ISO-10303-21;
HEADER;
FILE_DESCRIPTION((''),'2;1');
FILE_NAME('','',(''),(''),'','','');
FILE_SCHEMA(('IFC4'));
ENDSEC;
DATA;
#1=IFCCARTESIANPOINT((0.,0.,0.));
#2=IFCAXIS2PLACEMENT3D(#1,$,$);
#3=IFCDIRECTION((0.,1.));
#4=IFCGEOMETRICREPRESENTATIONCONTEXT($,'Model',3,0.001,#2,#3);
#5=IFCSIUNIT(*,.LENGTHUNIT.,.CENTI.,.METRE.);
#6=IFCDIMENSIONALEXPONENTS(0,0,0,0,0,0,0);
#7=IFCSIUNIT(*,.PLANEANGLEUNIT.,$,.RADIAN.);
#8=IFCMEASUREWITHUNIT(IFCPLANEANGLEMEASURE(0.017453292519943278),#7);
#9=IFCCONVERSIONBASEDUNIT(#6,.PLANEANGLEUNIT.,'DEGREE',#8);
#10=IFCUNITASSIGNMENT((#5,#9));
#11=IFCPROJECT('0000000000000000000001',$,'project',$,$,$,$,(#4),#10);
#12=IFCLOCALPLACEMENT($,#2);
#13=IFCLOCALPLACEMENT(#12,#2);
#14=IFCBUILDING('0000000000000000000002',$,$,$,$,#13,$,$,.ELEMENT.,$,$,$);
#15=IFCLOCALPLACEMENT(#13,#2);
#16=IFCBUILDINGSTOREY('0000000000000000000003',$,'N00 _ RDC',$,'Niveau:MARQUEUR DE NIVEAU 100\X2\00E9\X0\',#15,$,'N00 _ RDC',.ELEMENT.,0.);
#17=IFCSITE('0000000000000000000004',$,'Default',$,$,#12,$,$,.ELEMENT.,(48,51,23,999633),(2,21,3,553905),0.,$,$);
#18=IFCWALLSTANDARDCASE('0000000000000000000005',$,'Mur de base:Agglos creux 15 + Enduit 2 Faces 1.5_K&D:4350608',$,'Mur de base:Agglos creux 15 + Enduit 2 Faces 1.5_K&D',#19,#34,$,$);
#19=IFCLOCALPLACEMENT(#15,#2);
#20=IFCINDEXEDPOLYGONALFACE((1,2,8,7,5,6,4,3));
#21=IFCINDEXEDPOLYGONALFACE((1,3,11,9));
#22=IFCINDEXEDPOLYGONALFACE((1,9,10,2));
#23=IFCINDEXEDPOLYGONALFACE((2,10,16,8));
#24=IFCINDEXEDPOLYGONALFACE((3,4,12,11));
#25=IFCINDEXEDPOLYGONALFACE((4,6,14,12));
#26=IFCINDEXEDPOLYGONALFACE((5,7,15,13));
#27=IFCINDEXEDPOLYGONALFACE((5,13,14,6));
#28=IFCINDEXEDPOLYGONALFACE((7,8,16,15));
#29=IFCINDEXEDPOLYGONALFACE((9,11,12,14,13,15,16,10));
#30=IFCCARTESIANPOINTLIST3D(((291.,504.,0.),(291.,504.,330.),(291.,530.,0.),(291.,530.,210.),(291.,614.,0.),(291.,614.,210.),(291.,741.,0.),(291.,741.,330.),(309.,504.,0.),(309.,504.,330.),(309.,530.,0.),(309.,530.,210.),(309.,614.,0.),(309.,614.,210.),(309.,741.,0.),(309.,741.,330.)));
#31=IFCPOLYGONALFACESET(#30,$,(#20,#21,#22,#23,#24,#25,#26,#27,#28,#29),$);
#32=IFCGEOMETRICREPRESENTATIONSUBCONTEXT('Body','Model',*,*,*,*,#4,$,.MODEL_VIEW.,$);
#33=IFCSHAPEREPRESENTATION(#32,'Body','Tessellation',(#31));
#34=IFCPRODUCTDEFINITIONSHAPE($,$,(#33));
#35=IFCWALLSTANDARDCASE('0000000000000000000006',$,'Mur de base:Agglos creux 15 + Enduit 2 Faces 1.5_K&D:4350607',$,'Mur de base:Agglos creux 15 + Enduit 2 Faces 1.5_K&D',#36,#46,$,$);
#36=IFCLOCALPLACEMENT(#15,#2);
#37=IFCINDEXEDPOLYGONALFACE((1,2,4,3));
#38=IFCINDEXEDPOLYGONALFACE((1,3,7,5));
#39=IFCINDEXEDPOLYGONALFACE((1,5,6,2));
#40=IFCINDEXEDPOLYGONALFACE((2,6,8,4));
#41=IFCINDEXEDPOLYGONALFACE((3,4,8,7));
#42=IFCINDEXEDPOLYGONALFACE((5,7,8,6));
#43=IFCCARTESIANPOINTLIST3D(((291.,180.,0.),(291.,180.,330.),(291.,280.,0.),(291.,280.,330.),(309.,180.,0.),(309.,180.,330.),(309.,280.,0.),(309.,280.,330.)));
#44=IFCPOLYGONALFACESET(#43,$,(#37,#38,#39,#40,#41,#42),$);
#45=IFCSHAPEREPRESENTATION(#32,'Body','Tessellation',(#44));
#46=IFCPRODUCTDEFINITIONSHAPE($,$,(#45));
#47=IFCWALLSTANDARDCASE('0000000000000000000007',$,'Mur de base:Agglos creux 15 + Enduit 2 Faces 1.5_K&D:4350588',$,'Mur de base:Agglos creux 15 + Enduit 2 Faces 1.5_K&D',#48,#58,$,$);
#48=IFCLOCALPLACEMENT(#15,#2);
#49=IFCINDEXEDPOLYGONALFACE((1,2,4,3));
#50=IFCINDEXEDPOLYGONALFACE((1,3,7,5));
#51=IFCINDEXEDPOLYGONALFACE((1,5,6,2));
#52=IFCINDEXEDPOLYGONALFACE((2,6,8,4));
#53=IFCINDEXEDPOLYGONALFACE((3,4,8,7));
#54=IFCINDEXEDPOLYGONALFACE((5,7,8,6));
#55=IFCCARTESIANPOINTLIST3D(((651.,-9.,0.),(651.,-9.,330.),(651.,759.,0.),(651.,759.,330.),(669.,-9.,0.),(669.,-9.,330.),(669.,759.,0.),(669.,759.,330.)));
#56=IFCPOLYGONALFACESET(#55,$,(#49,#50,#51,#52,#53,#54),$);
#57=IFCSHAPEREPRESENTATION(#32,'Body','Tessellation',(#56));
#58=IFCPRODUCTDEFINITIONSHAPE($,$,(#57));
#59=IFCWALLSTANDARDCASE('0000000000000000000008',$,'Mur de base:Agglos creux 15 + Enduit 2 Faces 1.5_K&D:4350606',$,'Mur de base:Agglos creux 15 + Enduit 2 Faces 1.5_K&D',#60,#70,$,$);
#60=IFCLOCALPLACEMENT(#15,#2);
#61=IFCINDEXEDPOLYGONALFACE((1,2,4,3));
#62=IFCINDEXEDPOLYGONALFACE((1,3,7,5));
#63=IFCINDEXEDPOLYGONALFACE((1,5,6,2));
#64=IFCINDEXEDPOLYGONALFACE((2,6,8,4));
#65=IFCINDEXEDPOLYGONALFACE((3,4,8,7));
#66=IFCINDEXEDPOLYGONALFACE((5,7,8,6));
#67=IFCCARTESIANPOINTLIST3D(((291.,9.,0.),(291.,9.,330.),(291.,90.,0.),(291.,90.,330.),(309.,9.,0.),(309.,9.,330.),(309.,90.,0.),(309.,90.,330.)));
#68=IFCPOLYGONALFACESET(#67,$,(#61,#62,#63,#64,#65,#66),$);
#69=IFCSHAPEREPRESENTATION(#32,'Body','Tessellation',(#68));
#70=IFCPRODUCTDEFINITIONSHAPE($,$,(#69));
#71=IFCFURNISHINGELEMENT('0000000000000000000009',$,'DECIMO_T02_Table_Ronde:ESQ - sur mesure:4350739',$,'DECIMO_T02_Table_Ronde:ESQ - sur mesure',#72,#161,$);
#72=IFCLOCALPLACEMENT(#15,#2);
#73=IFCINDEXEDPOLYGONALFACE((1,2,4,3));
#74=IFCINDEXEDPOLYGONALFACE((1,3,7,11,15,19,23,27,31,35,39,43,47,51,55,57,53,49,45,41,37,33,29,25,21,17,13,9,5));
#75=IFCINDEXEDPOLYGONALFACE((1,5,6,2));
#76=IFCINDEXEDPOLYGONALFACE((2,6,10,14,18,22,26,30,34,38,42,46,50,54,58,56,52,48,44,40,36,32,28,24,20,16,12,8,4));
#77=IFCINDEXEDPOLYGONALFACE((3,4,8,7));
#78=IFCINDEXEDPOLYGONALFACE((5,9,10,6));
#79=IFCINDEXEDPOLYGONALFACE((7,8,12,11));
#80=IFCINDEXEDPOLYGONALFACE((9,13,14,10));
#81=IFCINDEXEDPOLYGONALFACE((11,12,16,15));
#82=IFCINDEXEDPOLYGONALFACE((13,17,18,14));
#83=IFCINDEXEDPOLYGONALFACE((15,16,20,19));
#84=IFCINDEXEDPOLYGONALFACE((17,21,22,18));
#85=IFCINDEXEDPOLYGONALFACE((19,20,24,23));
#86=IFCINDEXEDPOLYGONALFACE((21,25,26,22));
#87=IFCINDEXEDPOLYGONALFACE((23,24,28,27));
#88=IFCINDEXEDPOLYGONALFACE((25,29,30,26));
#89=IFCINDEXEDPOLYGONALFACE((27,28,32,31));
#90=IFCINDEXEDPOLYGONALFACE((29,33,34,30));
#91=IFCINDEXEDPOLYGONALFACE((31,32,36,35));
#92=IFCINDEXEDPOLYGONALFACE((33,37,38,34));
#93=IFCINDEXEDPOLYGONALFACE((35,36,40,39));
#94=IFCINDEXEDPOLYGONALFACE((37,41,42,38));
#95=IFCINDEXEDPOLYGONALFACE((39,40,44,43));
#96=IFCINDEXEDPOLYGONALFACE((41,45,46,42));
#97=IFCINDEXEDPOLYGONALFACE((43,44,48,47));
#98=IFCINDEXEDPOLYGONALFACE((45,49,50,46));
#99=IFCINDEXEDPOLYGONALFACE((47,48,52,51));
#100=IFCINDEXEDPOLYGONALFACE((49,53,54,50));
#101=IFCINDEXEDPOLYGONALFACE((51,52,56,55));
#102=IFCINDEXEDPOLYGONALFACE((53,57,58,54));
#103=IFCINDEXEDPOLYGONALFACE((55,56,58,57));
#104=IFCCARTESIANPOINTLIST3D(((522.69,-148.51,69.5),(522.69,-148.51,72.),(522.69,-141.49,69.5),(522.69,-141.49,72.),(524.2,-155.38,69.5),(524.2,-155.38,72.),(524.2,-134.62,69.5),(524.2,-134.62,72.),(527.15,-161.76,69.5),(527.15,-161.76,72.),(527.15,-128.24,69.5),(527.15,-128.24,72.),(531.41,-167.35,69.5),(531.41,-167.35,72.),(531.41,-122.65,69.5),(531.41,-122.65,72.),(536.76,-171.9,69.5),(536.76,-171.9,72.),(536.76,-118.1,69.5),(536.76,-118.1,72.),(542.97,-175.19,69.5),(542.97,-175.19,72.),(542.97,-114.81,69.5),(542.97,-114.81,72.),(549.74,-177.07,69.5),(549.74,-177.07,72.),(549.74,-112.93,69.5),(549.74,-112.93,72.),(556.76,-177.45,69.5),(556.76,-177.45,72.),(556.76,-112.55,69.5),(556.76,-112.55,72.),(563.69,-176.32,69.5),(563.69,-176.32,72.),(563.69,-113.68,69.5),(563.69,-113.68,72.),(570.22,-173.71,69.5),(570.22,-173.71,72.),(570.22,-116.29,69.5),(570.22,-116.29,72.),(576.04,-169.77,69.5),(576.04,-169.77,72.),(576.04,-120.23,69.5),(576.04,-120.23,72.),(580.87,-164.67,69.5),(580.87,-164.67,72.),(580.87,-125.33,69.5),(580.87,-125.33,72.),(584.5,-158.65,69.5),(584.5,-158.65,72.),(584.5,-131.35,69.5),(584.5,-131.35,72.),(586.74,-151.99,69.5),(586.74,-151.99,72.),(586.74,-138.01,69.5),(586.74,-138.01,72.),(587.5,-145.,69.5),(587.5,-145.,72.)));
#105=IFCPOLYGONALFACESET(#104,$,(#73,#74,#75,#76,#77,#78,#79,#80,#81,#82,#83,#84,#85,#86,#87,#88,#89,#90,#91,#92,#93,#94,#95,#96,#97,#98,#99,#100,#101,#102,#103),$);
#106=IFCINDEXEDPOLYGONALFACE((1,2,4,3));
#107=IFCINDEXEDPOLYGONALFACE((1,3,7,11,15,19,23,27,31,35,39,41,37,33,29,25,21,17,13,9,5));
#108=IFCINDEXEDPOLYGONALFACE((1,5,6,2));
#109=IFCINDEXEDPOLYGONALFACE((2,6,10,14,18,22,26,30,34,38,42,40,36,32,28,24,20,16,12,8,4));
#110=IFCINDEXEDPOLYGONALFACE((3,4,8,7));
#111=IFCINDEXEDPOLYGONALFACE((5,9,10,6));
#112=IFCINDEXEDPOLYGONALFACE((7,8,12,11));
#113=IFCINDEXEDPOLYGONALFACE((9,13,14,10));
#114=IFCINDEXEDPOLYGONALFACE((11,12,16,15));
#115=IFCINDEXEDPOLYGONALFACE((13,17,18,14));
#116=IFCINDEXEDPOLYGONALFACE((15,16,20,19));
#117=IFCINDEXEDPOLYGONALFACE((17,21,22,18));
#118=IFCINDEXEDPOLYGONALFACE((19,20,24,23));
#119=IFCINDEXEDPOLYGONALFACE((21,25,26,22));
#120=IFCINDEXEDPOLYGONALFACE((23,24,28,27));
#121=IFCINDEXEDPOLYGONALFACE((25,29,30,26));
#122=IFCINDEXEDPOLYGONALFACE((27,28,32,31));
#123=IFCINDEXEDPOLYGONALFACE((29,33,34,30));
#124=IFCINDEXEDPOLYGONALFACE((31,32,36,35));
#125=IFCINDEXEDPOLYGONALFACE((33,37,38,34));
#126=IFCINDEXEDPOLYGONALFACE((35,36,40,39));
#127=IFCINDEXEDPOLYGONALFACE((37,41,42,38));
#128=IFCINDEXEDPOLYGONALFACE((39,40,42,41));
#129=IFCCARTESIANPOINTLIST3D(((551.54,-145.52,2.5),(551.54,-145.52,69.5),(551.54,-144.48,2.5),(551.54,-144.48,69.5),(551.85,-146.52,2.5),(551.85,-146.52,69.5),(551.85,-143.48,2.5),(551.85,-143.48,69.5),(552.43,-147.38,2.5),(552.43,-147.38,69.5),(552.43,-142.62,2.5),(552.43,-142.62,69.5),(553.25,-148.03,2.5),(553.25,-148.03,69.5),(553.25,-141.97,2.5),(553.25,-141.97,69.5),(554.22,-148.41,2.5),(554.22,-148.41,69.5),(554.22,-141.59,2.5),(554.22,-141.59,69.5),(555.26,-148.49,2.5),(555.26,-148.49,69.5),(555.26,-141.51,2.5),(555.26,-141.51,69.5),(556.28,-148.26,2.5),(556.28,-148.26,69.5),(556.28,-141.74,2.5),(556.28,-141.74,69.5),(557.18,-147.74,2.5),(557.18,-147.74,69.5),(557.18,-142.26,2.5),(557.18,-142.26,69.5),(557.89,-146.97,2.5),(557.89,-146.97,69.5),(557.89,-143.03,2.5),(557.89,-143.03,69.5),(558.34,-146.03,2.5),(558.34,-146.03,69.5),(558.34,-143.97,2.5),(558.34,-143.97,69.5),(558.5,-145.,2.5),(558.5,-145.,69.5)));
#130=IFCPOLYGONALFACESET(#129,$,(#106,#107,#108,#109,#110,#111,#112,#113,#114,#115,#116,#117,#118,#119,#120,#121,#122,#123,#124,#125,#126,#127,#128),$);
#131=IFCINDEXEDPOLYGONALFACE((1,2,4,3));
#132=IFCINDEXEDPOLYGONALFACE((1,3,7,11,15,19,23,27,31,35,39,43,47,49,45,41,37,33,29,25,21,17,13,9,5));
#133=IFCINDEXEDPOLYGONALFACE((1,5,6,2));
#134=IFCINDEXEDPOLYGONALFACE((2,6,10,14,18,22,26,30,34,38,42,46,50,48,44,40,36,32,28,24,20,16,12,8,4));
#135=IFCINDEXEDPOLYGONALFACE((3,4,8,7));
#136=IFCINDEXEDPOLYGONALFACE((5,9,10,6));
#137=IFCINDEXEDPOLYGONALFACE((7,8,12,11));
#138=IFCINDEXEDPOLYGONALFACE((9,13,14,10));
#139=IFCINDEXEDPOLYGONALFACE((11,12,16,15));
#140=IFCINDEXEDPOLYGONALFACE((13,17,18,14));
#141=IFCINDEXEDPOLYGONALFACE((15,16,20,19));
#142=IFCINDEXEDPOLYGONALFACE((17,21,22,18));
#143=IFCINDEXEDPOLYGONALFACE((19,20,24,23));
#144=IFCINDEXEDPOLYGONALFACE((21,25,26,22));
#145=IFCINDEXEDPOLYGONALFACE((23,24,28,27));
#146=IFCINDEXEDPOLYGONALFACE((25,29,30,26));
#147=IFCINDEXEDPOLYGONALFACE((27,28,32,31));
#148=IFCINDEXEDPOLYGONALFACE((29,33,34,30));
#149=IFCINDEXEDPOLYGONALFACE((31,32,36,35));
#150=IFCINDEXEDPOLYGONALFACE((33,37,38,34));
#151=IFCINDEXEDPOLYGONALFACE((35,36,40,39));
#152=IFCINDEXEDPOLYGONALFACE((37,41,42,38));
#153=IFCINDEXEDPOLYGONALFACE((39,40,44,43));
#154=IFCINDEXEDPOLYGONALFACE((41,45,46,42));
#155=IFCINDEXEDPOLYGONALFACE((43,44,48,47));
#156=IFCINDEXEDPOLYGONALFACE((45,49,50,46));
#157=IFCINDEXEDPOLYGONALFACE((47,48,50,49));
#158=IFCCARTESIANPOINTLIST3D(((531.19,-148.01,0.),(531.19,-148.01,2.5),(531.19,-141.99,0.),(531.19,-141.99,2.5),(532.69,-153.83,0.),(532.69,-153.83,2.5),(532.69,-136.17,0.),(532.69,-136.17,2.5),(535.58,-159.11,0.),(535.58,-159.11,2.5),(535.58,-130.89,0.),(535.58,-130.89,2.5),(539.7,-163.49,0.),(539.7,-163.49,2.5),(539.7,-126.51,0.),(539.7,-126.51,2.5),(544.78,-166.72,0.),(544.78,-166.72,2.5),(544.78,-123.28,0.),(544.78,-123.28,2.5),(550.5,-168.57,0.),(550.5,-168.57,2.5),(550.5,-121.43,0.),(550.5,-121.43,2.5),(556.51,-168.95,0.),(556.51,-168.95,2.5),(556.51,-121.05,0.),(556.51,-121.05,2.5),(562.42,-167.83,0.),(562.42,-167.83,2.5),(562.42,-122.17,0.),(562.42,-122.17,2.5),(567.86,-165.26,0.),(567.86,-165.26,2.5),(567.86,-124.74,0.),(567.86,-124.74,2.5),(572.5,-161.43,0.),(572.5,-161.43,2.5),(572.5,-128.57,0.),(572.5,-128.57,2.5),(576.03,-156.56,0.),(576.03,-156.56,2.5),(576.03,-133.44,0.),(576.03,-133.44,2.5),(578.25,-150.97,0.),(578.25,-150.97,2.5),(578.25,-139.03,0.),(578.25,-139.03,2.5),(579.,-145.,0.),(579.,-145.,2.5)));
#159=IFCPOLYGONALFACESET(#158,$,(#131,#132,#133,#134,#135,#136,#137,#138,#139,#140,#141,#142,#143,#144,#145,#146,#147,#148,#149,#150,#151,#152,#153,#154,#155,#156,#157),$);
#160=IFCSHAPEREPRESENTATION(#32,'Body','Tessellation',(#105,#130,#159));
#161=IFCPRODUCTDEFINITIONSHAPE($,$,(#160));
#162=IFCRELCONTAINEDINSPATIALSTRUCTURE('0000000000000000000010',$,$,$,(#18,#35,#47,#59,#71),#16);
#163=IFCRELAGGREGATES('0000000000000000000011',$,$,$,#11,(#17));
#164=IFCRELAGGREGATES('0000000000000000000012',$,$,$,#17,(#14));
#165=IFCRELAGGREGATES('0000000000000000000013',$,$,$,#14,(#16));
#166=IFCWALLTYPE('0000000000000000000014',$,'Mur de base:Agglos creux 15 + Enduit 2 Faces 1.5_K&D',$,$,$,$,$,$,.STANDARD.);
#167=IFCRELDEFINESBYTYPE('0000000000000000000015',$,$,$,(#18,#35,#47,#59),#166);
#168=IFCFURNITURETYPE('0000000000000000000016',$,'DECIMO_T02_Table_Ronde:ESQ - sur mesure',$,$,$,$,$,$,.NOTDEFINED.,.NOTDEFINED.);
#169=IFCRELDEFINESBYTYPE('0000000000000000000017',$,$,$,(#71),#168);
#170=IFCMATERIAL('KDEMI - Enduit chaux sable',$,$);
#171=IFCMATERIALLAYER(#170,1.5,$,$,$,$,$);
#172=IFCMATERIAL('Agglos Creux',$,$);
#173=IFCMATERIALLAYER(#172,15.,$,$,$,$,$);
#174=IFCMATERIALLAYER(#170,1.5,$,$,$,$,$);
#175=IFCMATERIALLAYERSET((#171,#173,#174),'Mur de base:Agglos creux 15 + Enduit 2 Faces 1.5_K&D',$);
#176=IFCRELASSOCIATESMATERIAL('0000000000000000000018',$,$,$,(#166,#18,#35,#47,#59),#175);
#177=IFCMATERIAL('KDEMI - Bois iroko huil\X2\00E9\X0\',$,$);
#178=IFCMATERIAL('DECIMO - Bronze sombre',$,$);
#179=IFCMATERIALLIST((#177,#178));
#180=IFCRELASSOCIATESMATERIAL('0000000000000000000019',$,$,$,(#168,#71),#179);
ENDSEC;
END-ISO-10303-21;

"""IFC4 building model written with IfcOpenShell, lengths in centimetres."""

from ifc_helpers import new_model, entity, si_unit, converted_unit, direction, frame, frame_2d, origin, place, context, subcontext, project, spatial, rectangle, circle, extrude, source, transform, mapped, material, material_list, layer, layer_set, layer_usage, type_object, type_shapes, element, save


model = new_model("IFC4")

# Units and contexts
model_context = context("Model", 3, precision=0.001, world=origin(), true_north=direction((0.0, 1.0)))
body_context = subcontext(model_context, "Body", "Model", "MODEL_VIEW")
ifc_project = project(units=[si_unit("LENGTHUNIT", "METRE", prefix="CENTI"), converted_unit("PLANEANGLEUNIT", "DEGREE", entity("IfcPlaneAngleMeasure", 0.017453292519943278), si_unit("PLANEANGLEUNIT", "RADIAN"), dimensions=[0, 0, 0, 0, 0, 0, 0])], contexts=[model_context])

# Site, building, storey
site_placement = place(None, origin())
site = spatial("IfcSite", under=ifc_project, at=site_placement, Name="Default", CompositionType="ELEMENT", RefLatitude=(48, 51, 23, 999633), RefLongitude=(2, 21, 3, 553905), RefElevation=0.0)
building_placement = place(site_placement, origin())
building = spatial("IfcBuilding", under=site, at=building_placement, CompositionType="ELEMENT")
storey_placement = place(building_placement, origin())
storey = spatial("IfcBuildingStorey", under=building, at=storey_placement, Name="N00 _ RDC", ObjectType="Niveau:MARQUEUR DE NIVEAU 100é", LongName="N00 _ RDC", CompositionType="ELEMENT", Elevation=0.0)

# Wall, opening
ifc_material_1 = material(Name="KDEMI - Enduit chaux sable")
ifc_layer_1 = layer(ifc_material_1, 1.5)
ifc_material_2 = material(Name="Agglos Creux")
ifc_layer_2 = layer(ifc_material_2, 15.0)
ifc_layer_3 = layer(ifc_material_1, 1.5)
ifc_layer_set = layer_set([ifc_layer_1, ifc_layer_2, ifc_layer_3], Name="Mur de base:Agglos creux 15 + Enduit 2 Faces 1.5_K&D")
ifc_layer_usage_1 = layer_usage(ifc_layer_set, "AXIS2", "POSITIVE", -9.0)
wall_type = type_object("IfcWallType", Name="Mur de base:Agglos creux 15 + Enduit 2 Faces 1.5_K&D", PredefinedType="STANDARD", material=ifc_layer_set)
wall_1_placement = place(storey_placement, frame((300.0, 504.0, 0.0), z_axis=(0.0, 0.0, 1.0), x_axis=(0.0, 1.0, 0.0)))
wall_1 = element("IfcWallStandardCase", 1, at=wall_1_placement, inside=storey, type_object=wall_type, material=ifc_layer_usage_1, Name="Mur de base:Agglos creux 15 + Enduit 2 Faces 1.5_K&D:4350608", ObjectType="Mur de base:Agglos creux 15 + Enduit 2 Faces 1.5_K&D", context=body_context, shape_type="SweptSolid", body=[
    extrude(rectangle(XDim=237.0, YDim=18.0, at=frame_2d((118.5, 0.0), x_axis=(1.0, 0.0))), origin(), (0.0, 0.0, 1.0), 330.0),
])
opening_placement = place(wall_1_placement, frame((-504.0, 300.0, 0.0), z_axis=(0.0, 0.0, 1.0), x_axis=(0.0, -1.0, 0.0)))
element("IfcOpeningElement", 2, at=opening_placement, inside=storey, cuts=wall_1, context=body_context, shape_type="SweptSolid", body=[
    extrude(rectangle(XDim=22.0, YDim=84.0, at=frame_2d((300.0, 572.0))), origin(), (0.0, 0.0, 1.0), 210.0),
])

# Walls
ifc_layer_usage_2 = layer_usage(ifc_layer_set, "AXIS2", "NEGATIVE", 9.0)
wall_2_placement = place(storey_placement, frame((300.0, 180.0, 0.0), z_axis=(0.0, 0.0, 1.0), x_axis=(0.0, 1.0, 0.0)))
element("IfcWallStandardCase", 3, at=wall_2_placement, inside=storey, type_object=wall_type, material=ifc_layer_usage_2, Name="Mur de base:Agglos creux 15 + Enduit 2 Faces 1.5_K&D:4350607", ObjectType="Mur de base:Agglos creux 15 + Enduit 2 Faces 1.5_K&D", context=body_context, shape_type="SweptSolid", body=[
    extrude(rectangle(XDim=100.0, YDim=18.0, at=frame_2d((50.0, 0.0), x_axis=(-1.0, 0.0))), origin(), (0.0, 0.0, 1.0), 330.0),
])
ifc_layer_usage_3 = layer_usage(ifc_layer_set, "AXIS2", "NEGATIVE", 9.0)
wall_3_placement = place(storey_placement, frame((660.0, -9.0, 0.0), z_axis=(0.0, 0.0, 1.0), x_axis=(0.0, 1.0, 0.0)))
element("IfcWallStandardCase", 4, at=wall_3_placement, inside=storey, type_object=wall_type, material=ifc_layer_usage_3, Name="Mur de base:Agglos creux 15 + Enduit 2 Faces 1.5_K&D:4350588", ObjectType="Mur de base:Agglos creux 15 + Enduit 2 Faces 1.5_K&D", context=body_context, shape_type="SweptSolid", body=[
    extrude(rectangle(XDim=768.0, YDim=18.0, at=frame_2d((384.0, 0.0), x_axis=(-1.0, 0.0))), origin(), (0.0, 0.0, 1.0), 330.0),
])
ifc_layer_usage_4 = layer_usage(ifc_layer_set, "AXIS2", "NEGATIVE", 9.0)
wall_4_placement = place(storey_placement, frame((300.0, 9.0, 0.0), z_axis=(0.0, 0.0, 1.0), x_axis=(0.0, 1.0, 0.0)))
element("IfcWallStandardCase", 5, at=wall_4_placement, inside=storey, type_object=wall_type, material=ifc_layer_usage_4, Name="Mur de base:Agglos creux 15 + Enduit 2 Faces 1.5_K&D:4350606", ObjectType="Mur de base:Agglos creux 15 + Enduit 2 Faces 1.5_K&D", context=body_context, shape_type="SweptSolid", body=[
    extrude(rectangle(XDim=81.0, YDim=18.0, at=frame_2d((40.5, 0.0), x_axis=(-1.0, 0.0))), origin(), (0.0, 0.0, 1.0), 330.0),
])

# Furnishing element
ifc_material_3 = material(Name="KDEMI - Bois iroko huilé")
ifc_material_4 = material(Name="DECIMO - Bronze sombre")
ifc_material_list_1 = material_list([ifc_material_3, ifc_material_4])
furniture_type_1 = type_object("IfcFurnitureType", Name="DECIMO_T02_Table_Ronde:ESQ - sur mesure", AssemblyPlace="NOTDEFINED", material=ifc_material_list_1)
shared_shape_1 = source(origin(), body_context, "Body", "SweptSolid", [
    extrude(circle(Radius=32.5, at=frame_2d((0.0, 0.0), x_axis=(1.0, 0.0))), frame((0.0, 0.0, 69.5)), (0.0, 0.0, 1.0), 2.5),
    extrude(circle(Radius=3.5, at=frame_2d((0.0, 0.0), x_axis=(1.0, 0.0))), frame((0.0, 0.0, 2.5)), (0.0, 0.0, 1.0), 67.0),
    extrude(circle(Radius=24.0, at=frame_2d((0.0, 0.0), x_axis=(1.0, 0.0))), origin(), (0.0, 0.0, 1.0), 2.5),
])
type_shapes(furniture_type_1, [shared_shape_1])
for number, where, z_axis, x_axis, name in (
    (6, (555.0, -145.0, 0.0), (0.0, 0.0, 1.0), (1.0, 0.0, 0.0), "DECIMO_T02_Table_Ronde:ESQ - sur mesure:4350739"),
):
    element("IfcFurnishingElement", number, at=place(storey_placement, frame(where, z_axis=z_axis, x_axis=x_axis)), inside=storey, type_object=furniture_type_1, material=ifc_material_list_1, Name=name, ObjectType="DECIMO_T02_Table_Ronde:ESQ - sur mesure", context=body_context, shape_type="MappedRepresentation", body=[
        mapped(shared_shape_1, transform((0.0, 0.0, 0.0), scale=1.0)),
    ])

save(model, "model.ifc")
